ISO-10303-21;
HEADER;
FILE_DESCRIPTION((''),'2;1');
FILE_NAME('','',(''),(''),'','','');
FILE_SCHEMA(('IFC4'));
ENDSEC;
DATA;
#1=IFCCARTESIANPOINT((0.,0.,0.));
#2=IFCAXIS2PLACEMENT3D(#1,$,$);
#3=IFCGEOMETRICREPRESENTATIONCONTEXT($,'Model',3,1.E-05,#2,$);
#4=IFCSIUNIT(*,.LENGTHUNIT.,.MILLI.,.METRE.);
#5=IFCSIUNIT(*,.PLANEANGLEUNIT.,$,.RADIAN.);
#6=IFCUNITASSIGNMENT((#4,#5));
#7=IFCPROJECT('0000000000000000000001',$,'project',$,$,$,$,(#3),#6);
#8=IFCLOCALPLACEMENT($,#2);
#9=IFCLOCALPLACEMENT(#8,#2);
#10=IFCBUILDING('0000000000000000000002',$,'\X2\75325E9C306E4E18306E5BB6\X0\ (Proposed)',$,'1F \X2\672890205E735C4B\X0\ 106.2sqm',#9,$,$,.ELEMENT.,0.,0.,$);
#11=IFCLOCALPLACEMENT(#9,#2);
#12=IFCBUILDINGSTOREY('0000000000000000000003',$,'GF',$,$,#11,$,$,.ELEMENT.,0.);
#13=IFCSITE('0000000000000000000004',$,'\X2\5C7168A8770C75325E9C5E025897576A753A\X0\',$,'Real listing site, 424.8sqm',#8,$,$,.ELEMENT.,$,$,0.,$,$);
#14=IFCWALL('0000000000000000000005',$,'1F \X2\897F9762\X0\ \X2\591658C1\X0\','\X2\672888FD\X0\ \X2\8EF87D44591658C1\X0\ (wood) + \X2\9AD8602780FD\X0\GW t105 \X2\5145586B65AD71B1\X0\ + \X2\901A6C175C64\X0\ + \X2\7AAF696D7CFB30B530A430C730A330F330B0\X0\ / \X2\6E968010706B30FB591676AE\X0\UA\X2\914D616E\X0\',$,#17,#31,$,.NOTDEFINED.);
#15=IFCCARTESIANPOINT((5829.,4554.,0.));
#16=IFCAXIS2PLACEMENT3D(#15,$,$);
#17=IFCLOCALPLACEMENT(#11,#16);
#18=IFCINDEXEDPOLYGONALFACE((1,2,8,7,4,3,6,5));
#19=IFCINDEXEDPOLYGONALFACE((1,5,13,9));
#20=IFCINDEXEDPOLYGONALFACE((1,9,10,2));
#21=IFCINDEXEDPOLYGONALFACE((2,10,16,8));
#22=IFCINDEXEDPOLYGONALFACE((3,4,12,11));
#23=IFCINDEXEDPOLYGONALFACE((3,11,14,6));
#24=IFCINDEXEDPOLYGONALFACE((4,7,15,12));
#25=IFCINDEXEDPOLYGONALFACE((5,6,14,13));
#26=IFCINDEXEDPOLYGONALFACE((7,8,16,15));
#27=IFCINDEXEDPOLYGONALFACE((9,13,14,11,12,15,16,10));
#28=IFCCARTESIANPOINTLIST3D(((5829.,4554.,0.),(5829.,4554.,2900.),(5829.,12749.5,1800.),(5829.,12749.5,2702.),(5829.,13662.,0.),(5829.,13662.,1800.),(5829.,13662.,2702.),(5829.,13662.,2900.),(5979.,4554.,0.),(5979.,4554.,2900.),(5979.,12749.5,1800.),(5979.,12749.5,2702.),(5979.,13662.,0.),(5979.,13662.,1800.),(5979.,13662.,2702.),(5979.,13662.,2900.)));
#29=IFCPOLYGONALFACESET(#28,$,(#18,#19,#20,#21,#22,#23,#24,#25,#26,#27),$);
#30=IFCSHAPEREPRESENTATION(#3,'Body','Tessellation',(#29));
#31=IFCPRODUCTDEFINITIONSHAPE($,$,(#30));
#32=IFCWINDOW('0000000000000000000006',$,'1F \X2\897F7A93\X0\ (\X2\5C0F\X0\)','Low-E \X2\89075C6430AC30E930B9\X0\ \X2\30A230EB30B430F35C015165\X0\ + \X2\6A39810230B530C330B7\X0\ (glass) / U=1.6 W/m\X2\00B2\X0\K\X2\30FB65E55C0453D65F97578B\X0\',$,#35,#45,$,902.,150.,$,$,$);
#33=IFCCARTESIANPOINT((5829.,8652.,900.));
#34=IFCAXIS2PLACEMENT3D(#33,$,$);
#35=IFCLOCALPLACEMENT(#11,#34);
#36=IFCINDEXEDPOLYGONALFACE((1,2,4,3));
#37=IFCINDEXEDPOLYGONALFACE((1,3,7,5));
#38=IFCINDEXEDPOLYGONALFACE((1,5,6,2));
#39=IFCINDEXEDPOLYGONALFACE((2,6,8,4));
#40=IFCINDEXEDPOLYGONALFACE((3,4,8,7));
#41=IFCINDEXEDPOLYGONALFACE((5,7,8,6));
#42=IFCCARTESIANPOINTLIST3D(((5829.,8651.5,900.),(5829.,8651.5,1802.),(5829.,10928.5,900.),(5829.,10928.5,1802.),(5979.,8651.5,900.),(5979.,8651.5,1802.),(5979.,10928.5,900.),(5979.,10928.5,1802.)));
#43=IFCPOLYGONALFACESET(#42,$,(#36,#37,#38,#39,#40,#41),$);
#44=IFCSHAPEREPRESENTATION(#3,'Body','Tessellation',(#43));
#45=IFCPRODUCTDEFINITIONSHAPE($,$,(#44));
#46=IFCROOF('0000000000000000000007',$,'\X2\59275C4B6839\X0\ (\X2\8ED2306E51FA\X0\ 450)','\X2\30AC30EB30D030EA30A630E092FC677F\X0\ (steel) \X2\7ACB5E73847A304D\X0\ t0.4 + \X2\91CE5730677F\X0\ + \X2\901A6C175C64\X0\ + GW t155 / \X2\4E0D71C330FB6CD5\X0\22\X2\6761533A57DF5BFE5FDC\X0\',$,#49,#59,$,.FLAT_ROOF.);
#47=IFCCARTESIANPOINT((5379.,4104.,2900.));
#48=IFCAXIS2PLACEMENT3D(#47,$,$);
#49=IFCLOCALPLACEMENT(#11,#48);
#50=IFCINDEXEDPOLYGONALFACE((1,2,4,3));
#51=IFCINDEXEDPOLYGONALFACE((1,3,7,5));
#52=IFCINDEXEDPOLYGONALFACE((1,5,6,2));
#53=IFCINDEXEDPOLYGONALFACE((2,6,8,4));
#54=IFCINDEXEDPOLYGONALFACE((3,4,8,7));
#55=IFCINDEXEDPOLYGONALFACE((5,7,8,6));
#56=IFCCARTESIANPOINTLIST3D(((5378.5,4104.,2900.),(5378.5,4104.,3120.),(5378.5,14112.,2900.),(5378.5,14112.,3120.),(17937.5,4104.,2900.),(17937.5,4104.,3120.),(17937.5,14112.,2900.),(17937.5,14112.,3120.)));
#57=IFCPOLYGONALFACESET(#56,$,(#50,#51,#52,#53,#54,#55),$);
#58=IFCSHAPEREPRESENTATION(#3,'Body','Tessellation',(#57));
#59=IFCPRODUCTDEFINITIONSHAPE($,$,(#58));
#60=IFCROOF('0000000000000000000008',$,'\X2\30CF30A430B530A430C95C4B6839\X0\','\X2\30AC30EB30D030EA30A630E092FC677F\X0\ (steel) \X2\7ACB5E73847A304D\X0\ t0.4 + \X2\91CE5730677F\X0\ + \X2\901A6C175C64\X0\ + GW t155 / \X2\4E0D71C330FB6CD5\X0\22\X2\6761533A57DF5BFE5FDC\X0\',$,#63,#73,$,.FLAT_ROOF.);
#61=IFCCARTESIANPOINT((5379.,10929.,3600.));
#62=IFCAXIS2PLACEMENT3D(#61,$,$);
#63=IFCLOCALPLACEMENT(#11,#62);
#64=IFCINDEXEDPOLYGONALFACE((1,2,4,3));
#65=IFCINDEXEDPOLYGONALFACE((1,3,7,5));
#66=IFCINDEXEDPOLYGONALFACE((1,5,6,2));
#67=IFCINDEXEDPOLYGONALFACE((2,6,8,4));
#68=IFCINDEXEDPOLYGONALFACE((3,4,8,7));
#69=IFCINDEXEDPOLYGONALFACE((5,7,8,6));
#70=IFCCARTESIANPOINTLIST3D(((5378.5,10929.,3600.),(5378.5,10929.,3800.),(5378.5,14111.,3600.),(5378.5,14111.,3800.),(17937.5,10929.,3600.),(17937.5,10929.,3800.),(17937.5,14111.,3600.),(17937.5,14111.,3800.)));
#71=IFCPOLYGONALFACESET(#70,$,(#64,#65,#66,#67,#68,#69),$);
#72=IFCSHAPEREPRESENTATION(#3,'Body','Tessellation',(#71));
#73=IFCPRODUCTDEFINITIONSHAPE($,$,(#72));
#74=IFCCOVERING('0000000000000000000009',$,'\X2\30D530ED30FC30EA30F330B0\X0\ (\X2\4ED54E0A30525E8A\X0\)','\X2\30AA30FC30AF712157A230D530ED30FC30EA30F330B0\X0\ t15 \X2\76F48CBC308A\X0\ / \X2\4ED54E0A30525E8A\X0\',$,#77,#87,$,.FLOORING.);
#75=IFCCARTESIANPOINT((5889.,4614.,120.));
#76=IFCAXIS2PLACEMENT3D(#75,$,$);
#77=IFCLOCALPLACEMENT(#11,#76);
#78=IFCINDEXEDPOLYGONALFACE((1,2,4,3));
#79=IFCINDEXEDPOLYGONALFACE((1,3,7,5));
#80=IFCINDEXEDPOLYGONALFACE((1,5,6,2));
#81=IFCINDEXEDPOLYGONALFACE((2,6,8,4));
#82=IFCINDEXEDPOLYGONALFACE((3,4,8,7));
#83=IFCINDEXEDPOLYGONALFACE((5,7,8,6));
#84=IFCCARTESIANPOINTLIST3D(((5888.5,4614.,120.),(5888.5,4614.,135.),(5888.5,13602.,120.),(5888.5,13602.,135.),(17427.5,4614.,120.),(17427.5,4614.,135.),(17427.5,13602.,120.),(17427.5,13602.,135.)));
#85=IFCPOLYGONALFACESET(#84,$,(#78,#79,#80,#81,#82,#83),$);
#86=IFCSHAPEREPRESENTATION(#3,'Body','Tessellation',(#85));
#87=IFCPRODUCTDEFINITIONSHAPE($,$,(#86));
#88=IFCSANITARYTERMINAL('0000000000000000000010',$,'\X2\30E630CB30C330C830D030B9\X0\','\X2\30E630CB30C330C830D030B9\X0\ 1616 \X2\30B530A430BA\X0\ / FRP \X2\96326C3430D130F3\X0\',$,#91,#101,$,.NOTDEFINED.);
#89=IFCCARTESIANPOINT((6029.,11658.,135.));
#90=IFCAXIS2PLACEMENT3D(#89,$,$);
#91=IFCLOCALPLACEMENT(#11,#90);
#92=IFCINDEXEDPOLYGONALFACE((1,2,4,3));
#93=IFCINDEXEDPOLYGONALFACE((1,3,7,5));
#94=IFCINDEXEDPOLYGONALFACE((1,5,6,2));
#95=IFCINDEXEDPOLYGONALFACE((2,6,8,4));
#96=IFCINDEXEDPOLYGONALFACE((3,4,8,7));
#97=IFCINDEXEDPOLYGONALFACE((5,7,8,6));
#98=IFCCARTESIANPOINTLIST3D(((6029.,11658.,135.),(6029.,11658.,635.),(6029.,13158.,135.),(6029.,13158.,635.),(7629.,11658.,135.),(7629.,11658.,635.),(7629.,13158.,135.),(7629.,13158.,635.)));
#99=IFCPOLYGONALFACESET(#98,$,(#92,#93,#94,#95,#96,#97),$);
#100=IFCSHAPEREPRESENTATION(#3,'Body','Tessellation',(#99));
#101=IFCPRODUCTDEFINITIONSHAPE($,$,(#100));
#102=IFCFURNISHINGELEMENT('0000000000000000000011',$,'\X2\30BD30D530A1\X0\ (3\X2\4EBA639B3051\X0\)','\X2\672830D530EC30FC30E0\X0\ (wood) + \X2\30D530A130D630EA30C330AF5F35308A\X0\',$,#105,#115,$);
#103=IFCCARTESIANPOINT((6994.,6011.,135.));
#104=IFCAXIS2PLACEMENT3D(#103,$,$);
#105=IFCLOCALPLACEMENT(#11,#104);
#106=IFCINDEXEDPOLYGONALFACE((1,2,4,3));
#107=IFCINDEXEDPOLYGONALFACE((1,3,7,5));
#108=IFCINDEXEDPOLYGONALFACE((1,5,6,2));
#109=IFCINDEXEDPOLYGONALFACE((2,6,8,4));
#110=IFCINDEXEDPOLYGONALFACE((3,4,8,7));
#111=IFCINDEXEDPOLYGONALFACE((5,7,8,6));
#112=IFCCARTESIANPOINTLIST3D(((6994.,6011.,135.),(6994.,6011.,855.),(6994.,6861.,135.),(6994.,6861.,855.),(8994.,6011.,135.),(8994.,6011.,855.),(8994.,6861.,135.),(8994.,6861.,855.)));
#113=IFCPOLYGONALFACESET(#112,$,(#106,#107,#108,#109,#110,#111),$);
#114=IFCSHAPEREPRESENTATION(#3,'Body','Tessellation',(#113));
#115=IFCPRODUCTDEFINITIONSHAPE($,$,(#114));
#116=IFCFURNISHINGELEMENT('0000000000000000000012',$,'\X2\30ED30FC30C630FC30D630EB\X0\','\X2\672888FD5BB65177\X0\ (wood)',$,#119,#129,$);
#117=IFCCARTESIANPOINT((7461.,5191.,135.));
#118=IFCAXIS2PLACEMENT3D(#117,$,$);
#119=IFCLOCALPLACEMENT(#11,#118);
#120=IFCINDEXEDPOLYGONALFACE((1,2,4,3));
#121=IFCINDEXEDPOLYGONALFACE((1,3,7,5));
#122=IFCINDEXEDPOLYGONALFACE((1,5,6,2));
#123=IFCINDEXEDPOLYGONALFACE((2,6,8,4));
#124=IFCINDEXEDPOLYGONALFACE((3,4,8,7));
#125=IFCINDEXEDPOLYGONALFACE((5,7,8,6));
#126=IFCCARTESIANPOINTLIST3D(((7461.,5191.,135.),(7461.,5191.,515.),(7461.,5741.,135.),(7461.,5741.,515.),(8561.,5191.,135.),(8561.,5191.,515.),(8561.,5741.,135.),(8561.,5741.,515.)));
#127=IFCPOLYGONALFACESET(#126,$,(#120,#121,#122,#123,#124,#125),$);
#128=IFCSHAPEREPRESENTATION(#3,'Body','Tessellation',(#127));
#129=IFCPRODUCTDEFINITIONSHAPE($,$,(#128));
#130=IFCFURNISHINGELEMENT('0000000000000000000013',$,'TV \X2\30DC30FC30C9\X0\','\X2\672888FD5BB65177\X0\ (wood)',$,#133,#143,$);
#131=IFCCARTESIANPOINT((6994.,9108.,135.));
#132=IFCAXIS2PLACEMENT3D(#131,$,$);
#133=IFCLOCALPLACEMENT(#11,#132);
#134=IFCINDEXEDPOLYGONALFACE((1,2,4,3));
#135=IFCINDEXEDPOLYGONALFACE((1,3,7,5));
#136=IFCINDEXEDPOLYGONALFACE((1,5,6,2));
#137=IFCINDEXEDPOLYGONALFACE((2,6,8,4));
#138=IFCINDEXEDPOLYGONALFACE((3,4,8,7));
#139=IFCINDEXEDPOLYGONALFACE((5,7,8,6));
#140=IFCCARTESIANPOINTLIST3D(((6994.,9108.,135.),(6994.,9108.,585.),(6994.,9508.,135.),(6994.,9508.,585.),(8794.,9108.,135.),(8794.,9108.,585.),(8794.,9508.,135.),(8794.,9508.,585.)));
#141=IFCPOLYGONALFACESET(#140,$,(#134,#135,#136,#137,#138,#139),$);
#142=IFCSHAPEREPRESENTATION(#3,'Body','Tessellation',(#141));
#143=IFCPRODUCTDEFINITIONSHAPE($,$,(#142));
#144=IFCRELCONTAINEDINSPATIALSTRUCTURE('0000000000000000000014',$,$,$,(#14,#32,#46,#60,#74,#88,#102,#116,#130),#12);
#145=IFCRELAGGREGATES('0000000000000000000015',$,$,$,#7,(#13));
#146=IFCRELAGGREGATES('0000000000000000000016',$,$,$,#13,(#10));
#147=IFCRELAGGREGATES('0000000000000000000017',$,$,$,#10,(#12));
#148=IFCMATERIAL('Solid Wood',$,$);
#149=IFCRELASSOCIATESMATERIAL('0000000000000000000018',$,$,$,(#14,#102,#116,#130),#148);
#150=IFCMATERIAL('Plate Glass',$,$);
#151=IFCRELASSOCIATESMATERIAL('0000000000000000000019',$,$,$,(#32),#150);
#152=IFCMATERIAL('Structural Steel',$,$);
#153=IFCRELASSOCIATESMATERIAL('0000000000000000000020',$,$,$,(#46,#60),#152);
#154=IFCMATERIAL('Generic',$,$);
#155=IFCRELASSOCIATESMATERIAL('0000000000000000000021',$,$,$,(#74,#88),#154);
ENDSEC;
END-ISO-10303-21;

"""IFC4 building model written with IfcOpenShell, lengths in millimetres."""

from ifc_helpers import new_model, si_unit, frame, frame_2d, origin, place, context, project, spatial, rectangle, extrude, material, element, fill, save


model = new_model("IFC4")

# Units and contexts
model_context = context("Model", 3, precision=1e-05, world=origin())
ifc_project = project(units=[si_unit("LENGTHUNIT", "METRE", prefix="MILLI"), si_unit("PLANEANGLEUNIT", "RADIAN")], contexts=[model_context])

# Site, building, storey
site_placement = place(None, origin())
site = spatial("IfcSite", under=ifc_project, at=site_placement, Name="山梨県甲府市増坪町", ObjectType="Real listing site, 424.8sqm", CompositionType="ELEMENT", RefElevation=0.0)
building_placement = place(site_placement, origin())
building = spatial("IfcBuilding", under=site, at=building_placement, Name="甲府の丘の家 (Proposed)", ObjectType="1F 木造平屋 106.2sqm", CompositionType="ELEMENT", ElevationOfRefHeight=0.0, ElevationOfTerrain=0.0)
storey_placement = place(building_placement, origin())
storey = spatial("IfcBuildingStorey", under=building, at=storey_placement, Name="GF", CompositionType="ELEMENT", Elevation=0.0)

# Shared definitions
ifc_material_1 = material(Name="Solid Wood")

# Shared definitions
ifc_material_2 = material(Name="Plate Glass")

# Wall, opening, window
wall_1_placement = place(storey_placement, frame((5829.0, 4554.0, 0.0)))
wall_1 = element("IfcWall", 1, at=wall_1_placement, inside=storey, material=ifc_material_1, Name="1F 西面 外壁", Description="木製 軸組外壁 (wood) + 高性能GW t105 充填断熱 + 通気層 + 窯業系サイディング / 準耐火・外皮UA配慮", PredefinedType="NOTDEFINED", context=model_context, shape_type="SweptSolid", body=[
    extrude(rectangle(XDim=150.0, YDim=9108.0, at=frame_2d((75.0, 4554.0))), frame((5829.0, 4554.0, 0.0)), (0.0, 0.0, 1.0), 2900.0),
])
opening_1_placement = place(storey_placement, frame((5829.0, 8652.0, 900.0)))
opening_1 = element("IfcOpeningElement", 2, at=opening_1_placement, cuts=wall_1, PredefinedType="NOTDEFINED", context=model_context, shape_type="SweptSolid", body=[
    extrude(rectangle(XDim=150.0, YDim=2277.0, at=frame_2d((75.0, 1138.0))), frame((5829.0, 8652.0, 900.0)), (0.0, 0.0, 1.0), 902.0),
])
window_1_placement = place(storey_placement, frame((5829.0, 8652.0, 900.0)))
window_1 = element("IfcWindow", 3, at=window_1_placement, inside=storey, material=ifc_material_2, Name="1F 西窓 (小)", Description="Low-E 複層ガラス アルゴン封入 + 樹脂サッシ (glass) / U=1.6 W/m²K・日射取得型", OverallHeight=902.0, OverallWidth=150.0, context=model_context, shape_type="SweptSolid", body=[
    extrude(rectangle(XDim=150.0, YDim=2277.0, at=frame_2d((75.0, 1138.0))), frame((5829.0, 8652.0, 900.0)), (0.0, 0.0, 1.0), 902.0),
])
fill(opening_1, window_1)

# Roofs
ifc_material_3 = material(Name="Structural Steel")
roof_1_placement = place(storey_placement, frame((5379.0, 4104.0, 2900.0)))
element("IfcRoof", 4, at=roof_1_placement, inside=storey, material=ifc_material_3, Name="大屋根 (軒の出 450)", Description="ガルバリウム鋼板 (steel) 立平葺き t0.4 + 野地板 + 通気層 + GW t155 / 不燃・法22条区域対応", PredefinedType="FLAT_ROOF", context=model_context, shape_type="SweptSolid", body=[
    extrude(rectangle(XDim=12559.0, YDim=10008.0, at=frame_2d((6279.0, 5004.0))), frame((5379.0, 4104.0, 2900.0)), (0.0, 0.0, 1.0), 220.0),
])
roof_2_placement = place(storey_placement, frame((5379.0, 10929.0, 3600.0)))
element("IfcRoof", 5, at=roof_2_placement, inside=storey, material=ifc_material_3, Name="ハイサイド屋根", Description="ガルバリウム鋼板 (steel) 立平葺き t0.4 + 野地板 + 通気層 + GW t155 / 不燃・法22条区域対応", PredefinedType="FLAT_ROOF", context=model_context, shape_type="SweptSolid", body=[
    extrude(rectangle(XDim=12559.0, YDim=3182.0, at=frame_2d((6279.0, 1591.0))), frame((5379.0, 10929.0, 3600.0)), (0.0, 0.0, 1.0), 200.0),
])

# Covering
ifc_material_4 = material(Name="Generic")
covering_placement = place(storey_placement, frame((5889.0, 4614.0, 120.0)))
element("IfcCovering", 6, at=covering_placement, inside=storey, material=ifc_material_4, Name="フローリング (仕上げ床)", Description="オーク無垢フローリング t15 直貼り / 仕上げ床", PredefinedType="FLOORING", context=model_context, shape_type="SweptSolid", body=[
    extrude(rectangle(XDim=11539.0, YDim=8988.0, at=frame_2d((5769.0, 4494.0))), frame((5889.0, 4614.0, 120.0)), (0.0, 0.0, 1.0), 15.0),
])

# Sanitary terminal
sanitary_terminal_placement = place(storey_placement, frame((6029.0, 11658.0, 135.0)))
element("IfcSanitaryTerminal", 7, at=sanitary_terminal_placement, inside=storey, material=ifc_material_4, Name="ユニットバス", Description="ユニットバス 1616 サイズ / FRP 防水パン", PredefinedType="NOTDEFINED", context=model_context, shape_type="SweptSolid", body=[
    extrude(rectangle(XDim=1600.0, YDim=1500.0, at=frame_2d((800.0, 750.0))), frame((6029.0, 11658.0, 135.0)), (0.0, 0.0, 1.0), 500.0),
])

# Furnishing elements
furnishing_1_placement = place(storey_placement, frame((6994.0, 6011.0, 135.0)))
element("IfcFurnishingElement", 8, at=furnishing_1_placement, inside=storey, material=ifc_material_1, Name="ソファ (3人掛け)", Description="木フレーム (wood) + ファブリック張り", context=model_context, shape_type="SweptSolid", body=[
    extrude(rectangle(XDim=2000.0, YDim=850.0, at=frame_2d((1000.0, 425.0))), frame((6994.0, 6011.0, 135.0)), (0.0, 0.0, 1.0), 720.0),
])
furnishing_2_placement = place(storey_placement, frame((7461.0, 5191.0, 135.0)))
element("IfcFurnishingElement", 9, at=furnishing_2_placement, inside=storey, material=ifc_material_1, Name="ローテーブル", Description="木製家具 (wood)", context=model_context, shape_type="SweptSolid", body=[
    extrude(rectangle(XDim=1100.0, YDim=550.0, at=frame_2d((550.0, 275.0))), frame((7461.0, 5191.0, 135.0)), (0.0, 0.0, 1.0), 380.0),
])
furnishing_3_placement = place(storey_placement, frame((6994.0, 9108.0, 135.0)))
element("IfcFurnishingElement", 10, at=furnishing_3_placement, inside=storey, material=ifc_material_1, Name="TV ボード", Description="木製家具 (wood)", context=model_context, shape_type="SweptSolid", body=[
    extrude(rectangle(XDim=1800.0, YDim=400.0, at=frame_2d((900.0, 200.0))), frame((6994.0, 9108.0, 135.0)), (0.0, 0.0, 1.0), 450.0),
])

save(model, "model.ifc")
